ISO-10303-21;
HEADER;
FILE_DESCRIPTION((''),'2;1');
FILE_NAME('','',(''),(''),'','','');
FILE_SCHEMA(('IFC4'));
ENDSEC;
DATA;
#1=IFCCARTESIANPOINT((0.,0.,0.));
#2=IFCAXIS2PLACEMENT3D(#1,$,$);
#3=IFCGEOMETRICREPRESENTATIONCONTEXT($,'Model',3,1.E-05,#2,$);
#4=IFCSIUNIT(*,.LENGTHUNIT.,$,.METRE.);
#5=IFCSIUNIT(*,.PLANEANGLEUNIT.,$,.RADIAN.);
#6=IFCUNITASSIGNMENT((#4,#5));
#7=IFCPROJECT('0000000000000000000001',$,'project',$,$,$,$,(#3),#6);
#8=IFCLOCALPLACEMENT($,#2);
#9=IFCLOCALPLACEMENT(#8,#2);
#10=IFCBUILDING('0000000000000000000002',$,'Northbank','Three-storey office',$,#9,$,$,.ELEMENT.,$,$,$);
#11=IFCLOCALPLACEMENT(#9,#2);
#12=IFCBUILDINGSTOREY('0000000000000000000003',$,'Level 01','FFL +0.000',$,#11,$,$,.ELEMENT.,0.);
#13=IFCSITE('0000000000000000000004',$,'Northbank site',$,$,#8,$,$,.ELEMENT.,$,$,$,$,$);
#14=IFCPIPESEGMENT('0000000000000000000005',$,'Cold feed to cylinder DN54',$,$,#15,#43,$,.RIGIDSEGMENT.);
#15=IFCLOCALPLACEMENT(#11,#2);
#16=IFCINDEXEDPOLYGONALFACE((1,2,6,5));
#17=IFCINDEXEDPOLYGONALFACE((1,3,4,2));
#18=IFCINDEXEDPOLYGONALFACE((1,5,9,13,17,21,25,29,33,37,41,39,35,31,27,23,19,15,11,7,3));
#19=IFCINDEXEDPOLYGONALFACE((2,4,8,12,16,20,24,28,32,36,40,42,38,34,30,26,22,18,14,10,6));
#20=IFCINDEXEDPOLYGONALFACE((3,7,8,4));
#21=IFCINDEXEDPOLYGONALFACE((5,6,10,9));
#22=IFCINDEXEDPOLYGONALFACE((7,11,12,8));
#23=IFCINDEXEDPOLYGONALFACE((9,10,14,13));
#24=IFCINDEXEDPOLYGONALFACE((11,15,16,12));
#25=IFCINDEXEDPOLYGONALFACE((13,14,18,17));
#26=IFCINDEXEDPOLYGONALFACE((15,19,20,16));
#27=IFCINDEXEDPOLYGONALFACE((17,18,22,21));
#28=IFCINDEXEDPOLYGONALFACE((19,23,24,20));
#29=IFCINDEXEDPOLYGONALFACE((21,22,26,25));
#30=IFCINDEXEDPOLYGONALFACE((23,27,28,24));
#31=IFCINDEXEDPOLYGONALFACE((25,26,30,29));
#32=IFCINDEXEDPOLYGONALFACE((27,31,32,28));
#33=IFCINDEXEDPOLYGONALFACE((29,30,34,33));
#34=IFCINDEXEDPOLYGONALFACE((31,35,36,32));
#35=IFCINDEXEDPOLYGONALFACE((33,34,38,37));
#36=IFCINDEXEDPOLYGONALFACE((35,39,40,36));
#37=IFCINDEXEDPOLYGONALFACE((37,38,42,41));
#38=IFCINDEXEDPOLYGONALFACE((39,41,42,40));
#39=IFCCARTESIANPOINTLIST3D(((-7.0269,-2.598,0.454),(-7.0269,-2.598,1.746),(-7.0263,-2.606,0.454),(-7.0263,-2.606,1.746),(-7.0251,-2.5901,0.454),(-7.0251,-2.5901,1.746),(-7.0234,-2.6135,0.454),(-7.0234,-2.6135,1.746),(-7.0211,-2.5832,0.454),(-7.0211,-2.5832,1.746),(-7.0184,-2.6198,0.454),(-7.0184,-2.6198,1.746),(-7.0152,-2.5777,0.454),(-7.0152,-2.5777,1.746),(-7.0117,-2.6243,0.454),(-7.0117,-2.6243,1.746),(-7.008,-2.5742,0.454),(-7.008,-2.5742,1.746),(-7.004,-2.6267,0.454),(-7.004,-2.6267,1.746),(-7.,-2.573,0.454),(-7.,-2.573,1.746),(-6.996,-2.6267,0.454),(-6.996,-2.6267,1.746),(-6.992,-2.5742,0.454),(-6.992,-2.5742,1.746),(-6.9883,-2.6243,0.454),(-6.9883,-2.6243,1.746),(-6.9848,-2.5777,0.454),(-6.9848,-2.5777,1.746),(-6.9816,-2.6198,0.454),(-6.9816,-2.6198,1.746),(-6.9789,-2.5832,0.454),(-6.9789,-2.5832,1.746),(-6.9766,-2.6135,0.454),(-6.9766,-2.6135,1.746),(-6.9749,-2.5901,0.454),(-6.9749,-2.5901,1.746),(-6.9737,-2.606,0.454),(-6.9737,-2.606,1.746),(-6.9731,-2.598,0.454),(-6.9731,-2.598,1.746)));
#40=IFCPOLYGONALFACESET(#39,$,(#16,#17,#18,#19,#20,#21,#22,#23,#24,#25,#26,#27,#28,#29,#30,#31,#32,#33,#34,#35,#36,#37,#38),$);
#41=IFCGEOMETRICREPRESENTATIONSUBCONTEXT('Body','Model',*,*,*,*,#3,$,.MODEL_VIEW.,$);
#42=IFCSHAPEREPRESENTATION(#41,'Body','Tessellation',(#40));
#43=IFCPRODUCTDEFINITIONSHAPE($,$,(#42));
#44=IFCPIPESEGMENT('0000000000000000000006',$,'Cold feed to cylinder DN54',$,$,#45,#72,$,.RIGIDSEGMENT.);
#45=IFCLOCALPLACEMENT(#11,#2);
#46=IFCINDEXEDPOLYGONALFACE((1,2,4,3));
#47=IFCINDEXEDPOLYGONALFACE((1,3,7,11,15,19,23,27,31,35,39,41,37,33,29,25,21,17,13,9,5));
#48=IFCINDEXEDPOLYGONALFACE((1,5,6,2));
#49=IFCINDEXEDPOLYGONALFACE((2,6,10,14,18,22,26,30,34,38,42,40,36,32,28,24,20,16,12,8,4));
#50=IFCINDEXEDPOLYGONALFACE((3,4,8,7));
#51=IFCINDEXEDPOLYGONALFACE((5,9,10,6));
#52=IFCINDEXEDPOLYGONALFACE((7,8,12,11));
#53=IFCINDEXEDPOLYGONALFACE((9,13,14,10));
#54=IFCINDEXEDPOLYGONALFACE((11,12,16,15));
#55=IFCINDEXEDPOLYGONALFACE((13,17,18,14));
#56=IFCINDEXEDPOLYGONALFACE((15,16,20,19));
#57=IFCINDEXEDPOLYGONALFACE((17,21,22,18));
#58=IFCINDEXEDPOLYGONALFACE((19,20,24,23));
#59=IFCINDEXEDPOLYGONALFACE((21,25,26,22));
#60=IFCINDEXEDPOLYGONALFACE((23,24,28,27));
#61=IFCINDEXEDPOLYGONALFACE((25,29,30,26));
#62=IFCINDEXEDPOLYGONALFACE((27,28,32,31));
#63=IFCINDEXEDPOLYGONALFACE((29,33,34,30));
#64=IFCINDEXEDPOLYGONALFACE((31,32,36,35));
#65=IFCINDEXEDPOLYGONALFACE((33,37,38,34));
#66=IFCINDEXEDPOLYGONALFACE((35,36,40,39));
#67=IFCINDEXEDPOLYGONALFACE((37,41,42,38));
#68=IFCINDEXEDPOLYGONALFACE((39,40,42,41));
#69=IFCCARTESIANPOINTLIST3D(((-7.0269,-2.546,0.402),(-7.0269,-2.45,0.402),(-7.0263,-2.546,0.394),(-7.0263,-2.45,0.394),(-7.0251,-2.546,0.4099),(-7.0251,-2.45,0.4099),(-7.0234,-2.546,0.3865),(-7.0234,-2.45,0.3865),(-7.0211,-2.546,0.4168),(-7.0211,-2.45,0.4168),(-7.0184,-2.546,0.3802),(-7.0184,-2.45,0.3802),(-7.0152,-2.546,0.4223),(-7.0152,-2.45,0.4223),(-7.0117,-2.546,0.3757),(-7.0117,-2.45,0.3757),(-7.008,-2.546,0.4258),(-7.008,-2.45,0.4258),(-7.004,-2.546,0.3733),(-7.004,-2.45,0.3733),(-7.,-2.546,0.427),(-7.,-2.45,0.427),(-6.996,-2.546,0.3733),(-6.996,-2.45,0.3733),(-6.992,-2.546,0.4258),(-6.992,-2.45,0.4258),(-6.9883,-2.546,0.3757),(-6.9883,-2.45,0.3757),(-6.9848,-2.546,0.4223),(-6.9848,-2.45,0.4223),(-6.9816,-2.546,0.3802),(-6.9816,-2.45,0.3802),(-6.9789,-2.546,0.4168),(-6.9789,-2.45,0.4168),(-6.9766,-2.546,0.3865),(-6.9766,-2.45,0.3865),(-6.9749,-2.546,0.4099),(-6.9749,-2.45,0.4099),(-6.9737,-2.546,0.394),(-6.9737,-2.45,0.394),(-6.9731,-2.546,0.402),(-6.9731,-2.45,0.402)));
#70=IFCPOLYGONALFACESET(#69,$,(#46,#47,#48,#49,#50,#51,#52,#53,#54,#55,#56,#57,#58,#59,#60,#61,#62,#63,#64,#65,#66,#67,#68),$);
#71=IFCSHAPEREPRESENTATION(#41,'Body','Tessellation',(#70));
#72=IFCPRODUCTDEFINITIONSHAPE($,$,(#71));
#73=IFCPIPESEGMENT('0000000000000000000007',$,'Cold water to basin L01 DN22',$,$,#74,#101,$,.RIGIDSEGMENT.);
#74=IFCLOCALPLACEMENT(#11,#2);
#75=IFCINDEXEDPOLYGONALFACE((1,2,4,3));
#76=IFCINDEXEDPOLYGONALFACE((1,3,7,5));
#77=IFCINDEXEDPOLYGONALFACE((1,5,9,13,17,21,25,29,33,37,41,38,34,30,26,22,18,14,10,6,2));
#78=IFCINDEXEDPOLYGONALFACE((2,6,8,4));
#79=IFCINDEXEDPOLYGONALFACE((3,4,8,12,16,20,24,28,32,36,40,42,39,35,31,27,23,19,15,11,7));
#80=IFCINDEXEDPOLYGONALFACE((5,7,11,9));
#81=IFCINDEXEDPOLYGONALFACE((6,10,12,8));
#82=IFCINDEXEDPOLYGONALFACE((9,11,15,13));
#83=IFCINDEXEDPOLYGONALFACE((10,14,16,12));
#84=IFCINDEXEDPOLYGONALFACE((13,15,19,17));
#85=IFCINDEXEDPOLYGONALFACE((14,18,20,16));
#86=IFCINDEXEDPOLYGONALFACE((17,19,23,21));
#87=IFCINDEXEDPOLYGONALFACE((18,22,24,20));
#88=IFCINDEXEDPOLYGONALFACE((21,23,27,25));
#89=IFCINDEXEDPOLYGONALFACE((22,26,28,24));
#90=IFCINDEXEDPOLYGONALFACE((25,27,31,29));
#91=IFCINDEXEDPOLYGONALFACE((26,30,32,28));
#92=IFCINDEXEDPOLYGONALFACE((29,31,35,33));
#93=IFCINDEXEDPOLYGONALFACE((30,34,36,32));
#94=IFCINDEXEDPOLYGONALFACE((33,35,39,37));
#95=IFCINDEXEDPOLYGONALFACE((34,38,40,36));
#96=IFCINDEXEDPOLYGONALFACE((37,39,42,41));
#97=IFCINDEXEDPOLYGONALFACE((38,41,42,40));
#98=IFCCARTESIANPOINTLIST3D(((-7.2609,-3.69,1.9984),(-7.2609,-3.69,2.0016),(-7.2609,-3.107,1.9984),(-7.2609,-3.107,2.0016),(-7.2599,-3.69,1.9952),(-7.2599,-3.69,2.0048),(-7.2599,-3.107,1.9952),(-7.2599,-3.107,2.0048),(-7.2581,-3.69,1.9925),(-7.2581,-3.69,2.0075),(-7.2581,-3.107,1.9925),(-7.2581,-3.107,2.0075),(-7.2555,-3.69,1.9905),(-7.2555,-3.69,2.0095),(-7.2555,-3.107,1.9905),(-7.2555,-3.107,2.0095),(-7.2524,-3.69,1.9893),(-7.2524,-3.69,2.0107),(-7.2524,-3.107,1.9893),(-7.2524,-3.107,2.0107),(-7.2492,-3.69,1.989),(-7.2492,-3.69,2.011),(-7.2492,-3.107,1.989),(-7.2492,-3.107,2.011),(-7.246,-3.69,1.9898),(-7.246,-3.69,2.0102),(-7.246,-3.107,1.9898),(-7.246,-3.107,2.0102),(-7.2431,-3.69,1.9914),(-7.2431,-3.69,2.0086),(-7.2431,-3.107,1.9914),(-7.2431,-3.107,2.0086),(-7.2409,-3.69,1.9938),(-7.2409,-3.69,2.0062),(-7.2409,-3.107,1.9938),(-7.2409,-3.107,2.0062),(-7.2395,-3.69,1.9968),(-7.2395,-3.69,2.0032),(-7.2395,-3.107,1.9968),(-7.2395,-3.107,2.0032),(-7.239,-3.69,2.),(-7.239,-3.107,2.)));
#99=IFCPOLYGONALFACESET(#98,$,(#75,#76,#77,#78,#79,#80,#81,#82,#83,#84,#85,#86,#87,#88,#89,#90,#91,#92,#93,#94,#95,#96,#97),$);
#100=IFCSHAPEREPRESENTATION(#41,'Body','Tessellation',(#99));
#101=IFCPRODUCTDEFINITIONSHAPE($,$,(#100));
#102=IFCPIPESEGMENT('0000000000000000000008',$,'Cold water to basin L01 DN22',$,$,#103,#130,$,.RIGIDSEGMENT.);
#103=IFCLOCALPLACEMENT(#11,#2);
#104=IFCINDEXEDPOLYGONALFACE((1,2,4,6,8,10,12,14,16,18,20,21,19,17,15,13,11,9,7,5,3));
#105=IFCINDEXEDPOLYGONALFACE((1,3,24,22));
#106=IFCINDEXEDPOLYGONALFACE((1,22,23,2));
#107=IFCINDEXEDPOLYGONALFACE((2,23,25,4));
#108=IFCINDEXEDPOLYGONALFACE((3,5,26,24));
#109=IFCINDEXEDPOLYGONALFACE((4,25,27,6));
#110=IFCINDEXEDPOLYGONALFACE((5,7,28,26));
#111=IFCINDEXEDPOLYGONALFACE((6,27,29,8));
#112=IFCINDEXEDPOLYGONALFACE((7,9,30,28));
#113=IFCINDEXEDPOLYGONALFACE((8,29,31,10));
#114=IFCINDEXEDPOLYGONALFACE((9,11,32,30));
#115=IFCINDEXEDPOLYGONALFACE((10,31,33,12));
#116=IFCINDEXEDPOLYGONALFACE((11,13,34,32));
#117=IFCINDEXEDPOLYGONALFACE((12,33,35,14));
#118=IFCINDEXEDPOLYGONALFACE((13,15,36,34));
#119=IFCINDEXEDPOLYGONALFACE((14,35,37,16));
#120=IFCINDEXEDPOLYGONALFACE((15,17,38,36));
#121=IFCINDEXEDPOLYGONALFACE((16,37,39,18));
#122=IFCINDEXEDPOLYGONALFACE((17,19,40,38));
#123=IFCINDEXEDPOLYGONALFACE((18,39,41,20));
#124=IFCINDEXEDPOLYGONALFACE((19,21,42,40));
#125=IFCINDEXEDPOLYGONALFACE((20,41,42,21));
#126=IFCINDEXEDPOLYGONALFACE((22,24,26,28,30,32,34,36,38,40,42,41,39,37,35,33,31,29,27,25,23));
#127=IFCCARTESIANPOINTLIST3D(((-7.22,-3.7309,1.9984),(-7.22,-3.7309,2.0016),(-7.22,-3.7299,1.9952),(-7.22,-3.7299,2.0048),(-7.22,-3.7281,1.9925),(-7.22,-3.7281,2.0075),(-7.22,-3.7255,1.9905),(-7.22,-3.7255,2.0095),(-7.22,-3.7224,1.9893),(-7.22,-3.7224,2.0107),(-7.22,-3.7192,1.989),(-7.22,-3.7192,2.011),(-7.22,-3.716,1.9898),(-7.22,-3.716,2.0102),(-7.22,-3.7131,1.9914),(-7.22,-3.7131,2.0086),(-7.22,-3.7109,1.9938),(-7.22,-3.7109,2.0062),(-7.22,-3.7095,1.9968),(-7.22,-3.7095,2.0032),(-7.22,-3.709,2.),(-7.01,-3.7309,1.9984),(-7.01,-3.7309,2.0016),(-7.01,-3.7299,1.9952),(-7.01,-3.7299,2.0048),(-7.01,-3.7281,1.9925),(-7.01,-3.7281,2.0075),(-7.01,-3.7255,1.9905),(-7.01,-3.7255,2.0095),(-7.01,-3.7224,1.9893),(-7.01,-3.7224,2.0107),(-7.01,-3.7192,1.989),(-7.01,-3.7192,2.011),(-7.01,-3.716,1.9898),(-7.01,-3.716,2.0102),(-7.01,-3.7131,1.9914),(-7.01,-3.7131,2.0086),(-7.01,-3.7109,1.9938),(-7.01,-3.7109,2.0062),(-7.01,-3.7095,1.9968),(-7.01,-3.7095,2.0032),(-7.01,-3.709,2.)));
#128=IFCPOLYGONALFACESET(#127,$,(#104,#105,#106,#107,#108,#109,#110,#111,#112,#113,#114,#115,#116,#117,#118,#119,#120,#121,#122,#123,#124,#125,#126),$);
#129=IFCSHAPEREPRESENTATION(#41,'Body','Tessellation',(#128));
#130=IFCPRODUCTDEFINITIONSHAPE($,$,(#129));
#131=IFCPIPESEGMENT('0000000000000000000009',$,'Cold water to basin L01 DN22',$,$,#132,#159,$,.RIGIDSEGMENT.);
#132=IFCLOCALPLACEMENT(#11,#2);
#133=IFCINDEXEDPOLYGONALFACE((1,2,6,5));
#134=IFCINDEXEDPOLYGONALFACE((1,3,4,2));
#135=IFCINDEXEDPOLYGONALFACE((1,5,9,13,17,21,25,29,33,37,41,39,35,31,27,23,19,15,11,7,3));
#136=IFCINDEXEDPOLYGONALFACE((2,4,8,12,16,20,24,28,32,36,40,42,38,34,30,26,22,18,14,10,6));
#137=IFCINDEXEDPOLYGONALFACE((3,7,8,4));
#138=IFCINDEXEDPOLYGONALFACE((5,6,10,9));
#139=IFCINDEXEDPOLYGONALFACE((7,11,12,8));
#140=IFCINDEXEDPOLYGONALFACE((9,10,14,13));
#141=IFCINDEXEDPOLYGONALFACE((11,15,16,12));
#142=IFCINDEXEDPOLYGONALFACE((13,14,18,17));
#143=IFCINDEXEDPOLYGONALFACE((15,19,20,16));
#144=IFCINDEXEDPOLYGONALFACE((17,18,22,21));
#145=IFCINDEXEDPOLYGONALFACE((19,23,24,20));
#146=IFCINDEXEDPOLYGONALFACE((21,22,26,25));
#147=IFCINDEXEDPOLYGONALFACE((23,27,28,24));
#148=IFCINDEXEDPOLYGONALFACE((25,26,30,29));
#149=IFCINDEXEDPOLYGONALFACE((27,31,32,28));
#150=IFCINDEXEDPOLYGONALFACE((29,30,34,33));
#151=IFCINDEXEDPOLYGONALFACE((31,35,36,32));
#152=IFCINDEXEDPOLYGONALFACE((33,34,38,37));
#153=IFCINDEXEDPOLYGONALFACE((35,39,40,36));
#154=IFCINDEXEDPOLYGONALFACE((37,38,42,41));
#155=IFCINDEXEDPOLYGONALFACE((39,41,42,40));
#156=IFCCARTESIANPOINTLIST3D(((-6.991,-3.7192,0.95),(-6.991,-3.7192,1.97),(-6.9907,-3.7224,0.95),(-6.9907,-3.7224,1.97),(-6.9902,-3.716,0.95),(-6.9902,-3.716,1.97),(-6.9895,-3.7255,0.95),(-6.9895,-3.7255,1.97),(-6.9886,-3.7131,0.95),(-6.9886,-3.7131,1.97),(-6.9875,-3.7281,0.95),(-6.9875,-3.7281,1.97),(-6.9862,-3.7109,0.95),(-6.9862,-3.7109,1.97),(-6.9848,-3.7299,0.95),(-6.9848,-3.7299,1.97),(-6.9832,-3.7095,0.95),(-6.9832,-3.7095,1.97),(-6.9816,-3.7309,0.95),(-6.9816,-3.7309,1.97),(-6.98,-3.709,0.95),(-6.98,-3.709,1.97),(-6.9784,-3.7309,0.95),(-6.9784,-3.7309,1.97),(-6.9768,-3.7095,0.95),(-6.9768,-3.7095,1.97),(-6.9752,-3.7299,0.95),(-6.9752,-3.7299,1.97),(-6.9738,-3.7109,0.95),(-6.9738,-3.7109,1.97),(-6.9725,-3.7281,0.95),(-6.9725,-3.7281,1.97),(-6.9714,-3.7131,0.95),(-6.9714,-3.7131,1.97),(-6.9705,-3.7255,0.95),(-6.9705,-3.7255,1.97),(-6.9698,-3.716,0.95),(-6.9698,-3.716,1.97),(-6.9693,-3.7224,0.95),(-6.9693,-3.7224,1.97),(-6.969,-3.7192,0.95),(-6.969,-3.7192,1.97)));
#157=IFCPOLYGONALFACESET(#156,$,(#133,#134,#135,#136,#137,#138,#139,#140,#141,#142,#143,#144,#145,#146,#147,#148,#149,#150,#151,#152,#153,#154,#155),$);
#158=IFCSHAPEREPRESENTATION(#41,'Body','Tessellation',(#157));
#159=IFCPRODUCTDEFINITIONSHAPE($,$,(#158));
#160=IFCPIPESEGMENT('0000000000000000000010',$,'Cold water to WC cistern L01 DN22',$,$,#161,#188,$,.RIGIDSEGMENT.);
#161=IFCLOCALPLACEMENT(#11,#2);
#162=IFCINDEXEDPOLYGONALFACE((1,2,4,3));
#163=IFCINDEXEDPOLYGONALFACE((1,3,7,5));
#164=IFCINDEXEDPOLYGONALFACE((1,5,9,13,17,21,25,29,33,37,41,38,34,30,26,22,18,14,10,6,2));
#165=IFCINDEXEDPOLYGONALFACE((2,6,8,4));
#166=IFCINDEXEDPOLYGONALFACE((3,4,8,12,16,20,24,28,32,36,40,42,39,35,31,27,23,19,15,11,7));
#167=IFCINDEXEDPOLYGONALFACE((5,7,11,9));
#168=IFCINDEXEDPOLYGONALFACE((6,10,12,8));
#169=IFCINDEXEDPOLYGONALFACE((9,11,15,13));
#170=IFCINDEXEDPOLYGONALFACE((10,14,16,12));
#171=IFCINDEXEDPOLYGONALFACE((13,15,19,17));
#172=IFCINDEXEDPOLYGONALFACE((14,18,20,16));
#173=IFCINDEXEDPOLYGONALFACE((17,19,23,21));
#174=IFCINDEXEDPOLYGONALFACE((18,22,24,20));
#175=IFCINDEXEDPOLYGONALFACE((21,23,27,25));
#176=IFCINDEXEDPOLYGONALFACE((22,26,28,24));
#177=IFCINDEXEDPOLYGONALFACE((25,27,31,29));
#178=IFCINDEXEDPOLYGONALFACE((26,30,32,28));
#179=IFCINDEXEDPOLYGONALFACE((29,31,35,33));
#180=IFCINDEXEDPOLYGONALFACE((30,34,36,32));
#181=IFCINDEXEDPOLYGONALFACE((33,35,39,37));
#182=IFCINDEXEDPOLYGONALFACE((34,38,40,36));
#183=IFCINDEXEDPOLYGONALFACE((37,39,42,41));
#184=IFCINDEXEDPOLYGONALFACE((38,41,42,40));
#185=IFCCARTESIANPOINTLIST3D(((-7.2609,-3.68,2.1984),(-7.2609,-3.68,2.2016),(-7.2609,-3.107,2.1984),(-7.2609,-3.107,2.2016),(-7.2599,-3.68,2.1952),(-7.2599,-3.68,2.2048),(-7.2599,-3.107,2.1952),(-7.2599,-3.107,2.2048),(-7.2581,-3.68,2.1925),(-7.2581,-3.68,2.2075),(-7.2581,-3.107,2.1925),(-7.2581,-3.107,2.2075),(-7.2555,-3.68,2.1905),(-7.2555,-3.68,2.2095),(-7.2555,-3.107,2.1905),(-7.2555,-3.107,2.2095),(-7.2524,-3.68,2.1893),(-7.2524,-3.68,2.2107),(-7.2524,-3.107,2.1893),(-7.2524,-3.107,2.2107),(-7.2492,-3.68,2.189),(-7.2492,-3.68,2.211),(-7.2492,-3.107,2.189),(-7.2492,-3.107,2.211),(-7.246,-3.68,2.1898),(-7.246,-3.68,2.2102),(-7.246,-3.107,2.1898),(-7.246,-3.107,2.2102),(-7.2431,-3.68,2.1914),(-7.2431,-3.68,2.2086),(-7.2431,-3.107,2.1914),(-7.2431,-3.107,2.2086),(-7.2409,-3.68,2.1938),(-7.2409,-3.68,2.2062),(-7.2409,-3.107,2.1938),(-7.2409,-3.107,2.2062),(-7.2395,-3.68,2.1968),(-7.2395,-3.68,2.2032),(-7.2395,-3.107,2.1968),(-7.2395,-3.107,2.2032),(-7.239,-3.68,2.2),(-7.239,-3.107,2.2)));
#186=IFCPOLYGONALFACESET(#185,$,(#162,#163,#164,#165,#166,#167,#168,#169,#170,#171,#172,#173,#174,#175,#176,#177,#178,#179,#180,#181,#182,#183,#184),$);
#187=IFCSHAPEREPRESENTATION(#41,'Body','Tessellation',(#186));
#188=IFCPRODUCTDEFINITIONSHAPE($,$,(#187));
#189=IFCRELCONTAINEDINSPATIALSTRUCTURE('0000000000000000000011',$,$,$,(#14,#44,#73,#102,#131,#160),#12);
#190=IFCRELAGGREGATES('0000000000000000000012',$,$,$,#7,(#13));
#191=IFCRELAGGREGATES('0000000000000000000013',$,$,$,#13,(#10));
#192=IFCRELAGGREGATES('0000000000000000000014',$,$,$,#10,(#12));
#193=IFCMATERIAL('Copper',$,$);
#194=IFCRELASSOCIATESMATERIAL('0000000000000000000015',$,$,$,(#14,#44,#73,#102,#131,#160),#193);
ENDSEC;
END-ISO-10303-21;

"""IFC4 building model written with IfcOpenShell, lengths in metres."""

from ifc_helpers import new_model, si_unit, frame, origin, place, context, subcontext, project, spatial, circle, extrude, material, element, save


model = new_model("IFC4")

# Units and contexts
model_context = context("Model", 3, precision=1e-05, world=origin())
body_context = subcontext(model_context, "Body", "Model", "MODEL_VIEW")
ifc_project = project(units=[si_unit("LENGTHUNIT", "METRE"), si_unit("PLANEANGLEUNIT", "RADIAN")], contexts=[model_context])

# Site, building, storey
site_placement = place(None, origin())
site = spatial("IfcSite", under=ifc_project, at=site_placement, Name="Northbank site", CompositionType="ELEMENT")
building_placement = place(site_placement, origin())
building = spatial("IfcBuilding", under=site, at=building_placement, Name="Northbank", Description="Three-storey office", CompositionType="ELEMENT")
storey_placement = place(building_placement, origin())
storey = spatial("IfcBuildingStorey", under=building, at=storey_placement, Name="Level 01", Description="FFL +0.000", CompositionType="ELEMENT", Elevation=0.0)

# Shared definitions
ifc_material = material(Name="Copper")

# Pipe segments
pipe_segment_1_placement = place(storey_placement, origin())
element("IfcPipeSegment", 1, at=pipe_segment_1_placement, inside=storey, material=ifc_material, Name="Cold feed to cylinder DN54", PredefinedType="RIGIDSEGMENT", context=body_context, shape_type="SweptSolid", body=[
    extrude(circle(Radius=0.027), frame((-7.0, -2.6, 1.746), z_axis=(0.0, 0.0, -1.0), x_axis=(0.0, 1.0, 0.0)), (0.0, 0.0, 1.0), 1.292),
])
pipe_segment_2_placement = place(storey_placement, origin())
element("IfcPipeSegment", 2, at=pipe_segment_2_placement, inside=storey, material=ifc_material, Name="Cold feed to cylinder DN54", PredefinedType="RIGIDSEGMENT", context=body_context, shape_type="SweptSolid", body=[
    extrude(circle(Radius=0.027), frame((-7.0, -2.546, 0.4), z_axis=(0.0, 1.0, 0.0), x_axis=(0.0, 0.0, 1.0)), (0.0, 0.0, 1.0), 0.096),
])
pipe_segment_3_placement = place(storey_placement, origin())
element("IfcPipeSegment", 3, at=pipe_segment_3_placement, inside=storey, material=ifc_material, Name="Cold water to basin L01 DN22", PredefinedType="RIGIDSEGMENT", context=body_context, shape_type="SweptSolid", body=[
    extrude(circle(Radius=0.011), frame((-7.25, -3.107, 2.0), z_axis=(0.0, -1.0, 0.0), x_axis=(1.0, 0.0, 0.0)), (0.0, 0.0, 1.0), 0.583),
])
pipe_segment_4_placement = place(storey_placement, origin())
element("IfcPipeSegment", 4, at=pipe_segment_4_placement, inside=storey, material=ifc_material, Name="Cold water to basin L01 DN22", PredefinedType="RIGIDSEGMENT", context=body_context, shape_type="SweptSolid", body=[
    extrude(circle(Radius=0.011), frame((-7.22, -3.72, 2.0), z_axis=(1.0, 0.0, 0.0), x_axis=(0.0, 1.0, 0.0)), (0.0, 0.0, 1.0), 0.21),
])
pipe_segment_5_placement = place(storey_placement, origin())
element("IfcPipeSegment", 5, at=pipe_segment_5_placement, inside=storey, material=ifc_material, Name="Cold water to basin L01 DN22", PredefinedType="RIGIDSEGMENT", context=body_context, shape_type="SweptSolid", body=[
    extrude(circle(Radius=0.011), frame((-6.98, -3.72, 1.97), z_axis=(0.0, 0.0, -1.0), x_axis=(0.0, 1.0, 0.0)), (0.0, 0.0, 1.0), 1.02),
])
pipe_segment_6_placement = place(storey_placement, origin())
element("IfcPipeSegment", 6, at=pipe_segment_6_placement, inside=storey, material=ifc_material, Name="Cold water to WC cistern L01 DN22", PredefinedType="RIGIDSEGMENT", context=body_context, shape_type="SweptSolid", body=[
    extrude(circle(Radius=0.011), frame((-7.25, -3.107, 2.2), z_axis=(0.0, -1.0, 0.0), x_axis=(1.0, 0.0, 0.0)), (0.0, 0.0, 1.0), 0.573),
])

save(model, "model.ifc")
